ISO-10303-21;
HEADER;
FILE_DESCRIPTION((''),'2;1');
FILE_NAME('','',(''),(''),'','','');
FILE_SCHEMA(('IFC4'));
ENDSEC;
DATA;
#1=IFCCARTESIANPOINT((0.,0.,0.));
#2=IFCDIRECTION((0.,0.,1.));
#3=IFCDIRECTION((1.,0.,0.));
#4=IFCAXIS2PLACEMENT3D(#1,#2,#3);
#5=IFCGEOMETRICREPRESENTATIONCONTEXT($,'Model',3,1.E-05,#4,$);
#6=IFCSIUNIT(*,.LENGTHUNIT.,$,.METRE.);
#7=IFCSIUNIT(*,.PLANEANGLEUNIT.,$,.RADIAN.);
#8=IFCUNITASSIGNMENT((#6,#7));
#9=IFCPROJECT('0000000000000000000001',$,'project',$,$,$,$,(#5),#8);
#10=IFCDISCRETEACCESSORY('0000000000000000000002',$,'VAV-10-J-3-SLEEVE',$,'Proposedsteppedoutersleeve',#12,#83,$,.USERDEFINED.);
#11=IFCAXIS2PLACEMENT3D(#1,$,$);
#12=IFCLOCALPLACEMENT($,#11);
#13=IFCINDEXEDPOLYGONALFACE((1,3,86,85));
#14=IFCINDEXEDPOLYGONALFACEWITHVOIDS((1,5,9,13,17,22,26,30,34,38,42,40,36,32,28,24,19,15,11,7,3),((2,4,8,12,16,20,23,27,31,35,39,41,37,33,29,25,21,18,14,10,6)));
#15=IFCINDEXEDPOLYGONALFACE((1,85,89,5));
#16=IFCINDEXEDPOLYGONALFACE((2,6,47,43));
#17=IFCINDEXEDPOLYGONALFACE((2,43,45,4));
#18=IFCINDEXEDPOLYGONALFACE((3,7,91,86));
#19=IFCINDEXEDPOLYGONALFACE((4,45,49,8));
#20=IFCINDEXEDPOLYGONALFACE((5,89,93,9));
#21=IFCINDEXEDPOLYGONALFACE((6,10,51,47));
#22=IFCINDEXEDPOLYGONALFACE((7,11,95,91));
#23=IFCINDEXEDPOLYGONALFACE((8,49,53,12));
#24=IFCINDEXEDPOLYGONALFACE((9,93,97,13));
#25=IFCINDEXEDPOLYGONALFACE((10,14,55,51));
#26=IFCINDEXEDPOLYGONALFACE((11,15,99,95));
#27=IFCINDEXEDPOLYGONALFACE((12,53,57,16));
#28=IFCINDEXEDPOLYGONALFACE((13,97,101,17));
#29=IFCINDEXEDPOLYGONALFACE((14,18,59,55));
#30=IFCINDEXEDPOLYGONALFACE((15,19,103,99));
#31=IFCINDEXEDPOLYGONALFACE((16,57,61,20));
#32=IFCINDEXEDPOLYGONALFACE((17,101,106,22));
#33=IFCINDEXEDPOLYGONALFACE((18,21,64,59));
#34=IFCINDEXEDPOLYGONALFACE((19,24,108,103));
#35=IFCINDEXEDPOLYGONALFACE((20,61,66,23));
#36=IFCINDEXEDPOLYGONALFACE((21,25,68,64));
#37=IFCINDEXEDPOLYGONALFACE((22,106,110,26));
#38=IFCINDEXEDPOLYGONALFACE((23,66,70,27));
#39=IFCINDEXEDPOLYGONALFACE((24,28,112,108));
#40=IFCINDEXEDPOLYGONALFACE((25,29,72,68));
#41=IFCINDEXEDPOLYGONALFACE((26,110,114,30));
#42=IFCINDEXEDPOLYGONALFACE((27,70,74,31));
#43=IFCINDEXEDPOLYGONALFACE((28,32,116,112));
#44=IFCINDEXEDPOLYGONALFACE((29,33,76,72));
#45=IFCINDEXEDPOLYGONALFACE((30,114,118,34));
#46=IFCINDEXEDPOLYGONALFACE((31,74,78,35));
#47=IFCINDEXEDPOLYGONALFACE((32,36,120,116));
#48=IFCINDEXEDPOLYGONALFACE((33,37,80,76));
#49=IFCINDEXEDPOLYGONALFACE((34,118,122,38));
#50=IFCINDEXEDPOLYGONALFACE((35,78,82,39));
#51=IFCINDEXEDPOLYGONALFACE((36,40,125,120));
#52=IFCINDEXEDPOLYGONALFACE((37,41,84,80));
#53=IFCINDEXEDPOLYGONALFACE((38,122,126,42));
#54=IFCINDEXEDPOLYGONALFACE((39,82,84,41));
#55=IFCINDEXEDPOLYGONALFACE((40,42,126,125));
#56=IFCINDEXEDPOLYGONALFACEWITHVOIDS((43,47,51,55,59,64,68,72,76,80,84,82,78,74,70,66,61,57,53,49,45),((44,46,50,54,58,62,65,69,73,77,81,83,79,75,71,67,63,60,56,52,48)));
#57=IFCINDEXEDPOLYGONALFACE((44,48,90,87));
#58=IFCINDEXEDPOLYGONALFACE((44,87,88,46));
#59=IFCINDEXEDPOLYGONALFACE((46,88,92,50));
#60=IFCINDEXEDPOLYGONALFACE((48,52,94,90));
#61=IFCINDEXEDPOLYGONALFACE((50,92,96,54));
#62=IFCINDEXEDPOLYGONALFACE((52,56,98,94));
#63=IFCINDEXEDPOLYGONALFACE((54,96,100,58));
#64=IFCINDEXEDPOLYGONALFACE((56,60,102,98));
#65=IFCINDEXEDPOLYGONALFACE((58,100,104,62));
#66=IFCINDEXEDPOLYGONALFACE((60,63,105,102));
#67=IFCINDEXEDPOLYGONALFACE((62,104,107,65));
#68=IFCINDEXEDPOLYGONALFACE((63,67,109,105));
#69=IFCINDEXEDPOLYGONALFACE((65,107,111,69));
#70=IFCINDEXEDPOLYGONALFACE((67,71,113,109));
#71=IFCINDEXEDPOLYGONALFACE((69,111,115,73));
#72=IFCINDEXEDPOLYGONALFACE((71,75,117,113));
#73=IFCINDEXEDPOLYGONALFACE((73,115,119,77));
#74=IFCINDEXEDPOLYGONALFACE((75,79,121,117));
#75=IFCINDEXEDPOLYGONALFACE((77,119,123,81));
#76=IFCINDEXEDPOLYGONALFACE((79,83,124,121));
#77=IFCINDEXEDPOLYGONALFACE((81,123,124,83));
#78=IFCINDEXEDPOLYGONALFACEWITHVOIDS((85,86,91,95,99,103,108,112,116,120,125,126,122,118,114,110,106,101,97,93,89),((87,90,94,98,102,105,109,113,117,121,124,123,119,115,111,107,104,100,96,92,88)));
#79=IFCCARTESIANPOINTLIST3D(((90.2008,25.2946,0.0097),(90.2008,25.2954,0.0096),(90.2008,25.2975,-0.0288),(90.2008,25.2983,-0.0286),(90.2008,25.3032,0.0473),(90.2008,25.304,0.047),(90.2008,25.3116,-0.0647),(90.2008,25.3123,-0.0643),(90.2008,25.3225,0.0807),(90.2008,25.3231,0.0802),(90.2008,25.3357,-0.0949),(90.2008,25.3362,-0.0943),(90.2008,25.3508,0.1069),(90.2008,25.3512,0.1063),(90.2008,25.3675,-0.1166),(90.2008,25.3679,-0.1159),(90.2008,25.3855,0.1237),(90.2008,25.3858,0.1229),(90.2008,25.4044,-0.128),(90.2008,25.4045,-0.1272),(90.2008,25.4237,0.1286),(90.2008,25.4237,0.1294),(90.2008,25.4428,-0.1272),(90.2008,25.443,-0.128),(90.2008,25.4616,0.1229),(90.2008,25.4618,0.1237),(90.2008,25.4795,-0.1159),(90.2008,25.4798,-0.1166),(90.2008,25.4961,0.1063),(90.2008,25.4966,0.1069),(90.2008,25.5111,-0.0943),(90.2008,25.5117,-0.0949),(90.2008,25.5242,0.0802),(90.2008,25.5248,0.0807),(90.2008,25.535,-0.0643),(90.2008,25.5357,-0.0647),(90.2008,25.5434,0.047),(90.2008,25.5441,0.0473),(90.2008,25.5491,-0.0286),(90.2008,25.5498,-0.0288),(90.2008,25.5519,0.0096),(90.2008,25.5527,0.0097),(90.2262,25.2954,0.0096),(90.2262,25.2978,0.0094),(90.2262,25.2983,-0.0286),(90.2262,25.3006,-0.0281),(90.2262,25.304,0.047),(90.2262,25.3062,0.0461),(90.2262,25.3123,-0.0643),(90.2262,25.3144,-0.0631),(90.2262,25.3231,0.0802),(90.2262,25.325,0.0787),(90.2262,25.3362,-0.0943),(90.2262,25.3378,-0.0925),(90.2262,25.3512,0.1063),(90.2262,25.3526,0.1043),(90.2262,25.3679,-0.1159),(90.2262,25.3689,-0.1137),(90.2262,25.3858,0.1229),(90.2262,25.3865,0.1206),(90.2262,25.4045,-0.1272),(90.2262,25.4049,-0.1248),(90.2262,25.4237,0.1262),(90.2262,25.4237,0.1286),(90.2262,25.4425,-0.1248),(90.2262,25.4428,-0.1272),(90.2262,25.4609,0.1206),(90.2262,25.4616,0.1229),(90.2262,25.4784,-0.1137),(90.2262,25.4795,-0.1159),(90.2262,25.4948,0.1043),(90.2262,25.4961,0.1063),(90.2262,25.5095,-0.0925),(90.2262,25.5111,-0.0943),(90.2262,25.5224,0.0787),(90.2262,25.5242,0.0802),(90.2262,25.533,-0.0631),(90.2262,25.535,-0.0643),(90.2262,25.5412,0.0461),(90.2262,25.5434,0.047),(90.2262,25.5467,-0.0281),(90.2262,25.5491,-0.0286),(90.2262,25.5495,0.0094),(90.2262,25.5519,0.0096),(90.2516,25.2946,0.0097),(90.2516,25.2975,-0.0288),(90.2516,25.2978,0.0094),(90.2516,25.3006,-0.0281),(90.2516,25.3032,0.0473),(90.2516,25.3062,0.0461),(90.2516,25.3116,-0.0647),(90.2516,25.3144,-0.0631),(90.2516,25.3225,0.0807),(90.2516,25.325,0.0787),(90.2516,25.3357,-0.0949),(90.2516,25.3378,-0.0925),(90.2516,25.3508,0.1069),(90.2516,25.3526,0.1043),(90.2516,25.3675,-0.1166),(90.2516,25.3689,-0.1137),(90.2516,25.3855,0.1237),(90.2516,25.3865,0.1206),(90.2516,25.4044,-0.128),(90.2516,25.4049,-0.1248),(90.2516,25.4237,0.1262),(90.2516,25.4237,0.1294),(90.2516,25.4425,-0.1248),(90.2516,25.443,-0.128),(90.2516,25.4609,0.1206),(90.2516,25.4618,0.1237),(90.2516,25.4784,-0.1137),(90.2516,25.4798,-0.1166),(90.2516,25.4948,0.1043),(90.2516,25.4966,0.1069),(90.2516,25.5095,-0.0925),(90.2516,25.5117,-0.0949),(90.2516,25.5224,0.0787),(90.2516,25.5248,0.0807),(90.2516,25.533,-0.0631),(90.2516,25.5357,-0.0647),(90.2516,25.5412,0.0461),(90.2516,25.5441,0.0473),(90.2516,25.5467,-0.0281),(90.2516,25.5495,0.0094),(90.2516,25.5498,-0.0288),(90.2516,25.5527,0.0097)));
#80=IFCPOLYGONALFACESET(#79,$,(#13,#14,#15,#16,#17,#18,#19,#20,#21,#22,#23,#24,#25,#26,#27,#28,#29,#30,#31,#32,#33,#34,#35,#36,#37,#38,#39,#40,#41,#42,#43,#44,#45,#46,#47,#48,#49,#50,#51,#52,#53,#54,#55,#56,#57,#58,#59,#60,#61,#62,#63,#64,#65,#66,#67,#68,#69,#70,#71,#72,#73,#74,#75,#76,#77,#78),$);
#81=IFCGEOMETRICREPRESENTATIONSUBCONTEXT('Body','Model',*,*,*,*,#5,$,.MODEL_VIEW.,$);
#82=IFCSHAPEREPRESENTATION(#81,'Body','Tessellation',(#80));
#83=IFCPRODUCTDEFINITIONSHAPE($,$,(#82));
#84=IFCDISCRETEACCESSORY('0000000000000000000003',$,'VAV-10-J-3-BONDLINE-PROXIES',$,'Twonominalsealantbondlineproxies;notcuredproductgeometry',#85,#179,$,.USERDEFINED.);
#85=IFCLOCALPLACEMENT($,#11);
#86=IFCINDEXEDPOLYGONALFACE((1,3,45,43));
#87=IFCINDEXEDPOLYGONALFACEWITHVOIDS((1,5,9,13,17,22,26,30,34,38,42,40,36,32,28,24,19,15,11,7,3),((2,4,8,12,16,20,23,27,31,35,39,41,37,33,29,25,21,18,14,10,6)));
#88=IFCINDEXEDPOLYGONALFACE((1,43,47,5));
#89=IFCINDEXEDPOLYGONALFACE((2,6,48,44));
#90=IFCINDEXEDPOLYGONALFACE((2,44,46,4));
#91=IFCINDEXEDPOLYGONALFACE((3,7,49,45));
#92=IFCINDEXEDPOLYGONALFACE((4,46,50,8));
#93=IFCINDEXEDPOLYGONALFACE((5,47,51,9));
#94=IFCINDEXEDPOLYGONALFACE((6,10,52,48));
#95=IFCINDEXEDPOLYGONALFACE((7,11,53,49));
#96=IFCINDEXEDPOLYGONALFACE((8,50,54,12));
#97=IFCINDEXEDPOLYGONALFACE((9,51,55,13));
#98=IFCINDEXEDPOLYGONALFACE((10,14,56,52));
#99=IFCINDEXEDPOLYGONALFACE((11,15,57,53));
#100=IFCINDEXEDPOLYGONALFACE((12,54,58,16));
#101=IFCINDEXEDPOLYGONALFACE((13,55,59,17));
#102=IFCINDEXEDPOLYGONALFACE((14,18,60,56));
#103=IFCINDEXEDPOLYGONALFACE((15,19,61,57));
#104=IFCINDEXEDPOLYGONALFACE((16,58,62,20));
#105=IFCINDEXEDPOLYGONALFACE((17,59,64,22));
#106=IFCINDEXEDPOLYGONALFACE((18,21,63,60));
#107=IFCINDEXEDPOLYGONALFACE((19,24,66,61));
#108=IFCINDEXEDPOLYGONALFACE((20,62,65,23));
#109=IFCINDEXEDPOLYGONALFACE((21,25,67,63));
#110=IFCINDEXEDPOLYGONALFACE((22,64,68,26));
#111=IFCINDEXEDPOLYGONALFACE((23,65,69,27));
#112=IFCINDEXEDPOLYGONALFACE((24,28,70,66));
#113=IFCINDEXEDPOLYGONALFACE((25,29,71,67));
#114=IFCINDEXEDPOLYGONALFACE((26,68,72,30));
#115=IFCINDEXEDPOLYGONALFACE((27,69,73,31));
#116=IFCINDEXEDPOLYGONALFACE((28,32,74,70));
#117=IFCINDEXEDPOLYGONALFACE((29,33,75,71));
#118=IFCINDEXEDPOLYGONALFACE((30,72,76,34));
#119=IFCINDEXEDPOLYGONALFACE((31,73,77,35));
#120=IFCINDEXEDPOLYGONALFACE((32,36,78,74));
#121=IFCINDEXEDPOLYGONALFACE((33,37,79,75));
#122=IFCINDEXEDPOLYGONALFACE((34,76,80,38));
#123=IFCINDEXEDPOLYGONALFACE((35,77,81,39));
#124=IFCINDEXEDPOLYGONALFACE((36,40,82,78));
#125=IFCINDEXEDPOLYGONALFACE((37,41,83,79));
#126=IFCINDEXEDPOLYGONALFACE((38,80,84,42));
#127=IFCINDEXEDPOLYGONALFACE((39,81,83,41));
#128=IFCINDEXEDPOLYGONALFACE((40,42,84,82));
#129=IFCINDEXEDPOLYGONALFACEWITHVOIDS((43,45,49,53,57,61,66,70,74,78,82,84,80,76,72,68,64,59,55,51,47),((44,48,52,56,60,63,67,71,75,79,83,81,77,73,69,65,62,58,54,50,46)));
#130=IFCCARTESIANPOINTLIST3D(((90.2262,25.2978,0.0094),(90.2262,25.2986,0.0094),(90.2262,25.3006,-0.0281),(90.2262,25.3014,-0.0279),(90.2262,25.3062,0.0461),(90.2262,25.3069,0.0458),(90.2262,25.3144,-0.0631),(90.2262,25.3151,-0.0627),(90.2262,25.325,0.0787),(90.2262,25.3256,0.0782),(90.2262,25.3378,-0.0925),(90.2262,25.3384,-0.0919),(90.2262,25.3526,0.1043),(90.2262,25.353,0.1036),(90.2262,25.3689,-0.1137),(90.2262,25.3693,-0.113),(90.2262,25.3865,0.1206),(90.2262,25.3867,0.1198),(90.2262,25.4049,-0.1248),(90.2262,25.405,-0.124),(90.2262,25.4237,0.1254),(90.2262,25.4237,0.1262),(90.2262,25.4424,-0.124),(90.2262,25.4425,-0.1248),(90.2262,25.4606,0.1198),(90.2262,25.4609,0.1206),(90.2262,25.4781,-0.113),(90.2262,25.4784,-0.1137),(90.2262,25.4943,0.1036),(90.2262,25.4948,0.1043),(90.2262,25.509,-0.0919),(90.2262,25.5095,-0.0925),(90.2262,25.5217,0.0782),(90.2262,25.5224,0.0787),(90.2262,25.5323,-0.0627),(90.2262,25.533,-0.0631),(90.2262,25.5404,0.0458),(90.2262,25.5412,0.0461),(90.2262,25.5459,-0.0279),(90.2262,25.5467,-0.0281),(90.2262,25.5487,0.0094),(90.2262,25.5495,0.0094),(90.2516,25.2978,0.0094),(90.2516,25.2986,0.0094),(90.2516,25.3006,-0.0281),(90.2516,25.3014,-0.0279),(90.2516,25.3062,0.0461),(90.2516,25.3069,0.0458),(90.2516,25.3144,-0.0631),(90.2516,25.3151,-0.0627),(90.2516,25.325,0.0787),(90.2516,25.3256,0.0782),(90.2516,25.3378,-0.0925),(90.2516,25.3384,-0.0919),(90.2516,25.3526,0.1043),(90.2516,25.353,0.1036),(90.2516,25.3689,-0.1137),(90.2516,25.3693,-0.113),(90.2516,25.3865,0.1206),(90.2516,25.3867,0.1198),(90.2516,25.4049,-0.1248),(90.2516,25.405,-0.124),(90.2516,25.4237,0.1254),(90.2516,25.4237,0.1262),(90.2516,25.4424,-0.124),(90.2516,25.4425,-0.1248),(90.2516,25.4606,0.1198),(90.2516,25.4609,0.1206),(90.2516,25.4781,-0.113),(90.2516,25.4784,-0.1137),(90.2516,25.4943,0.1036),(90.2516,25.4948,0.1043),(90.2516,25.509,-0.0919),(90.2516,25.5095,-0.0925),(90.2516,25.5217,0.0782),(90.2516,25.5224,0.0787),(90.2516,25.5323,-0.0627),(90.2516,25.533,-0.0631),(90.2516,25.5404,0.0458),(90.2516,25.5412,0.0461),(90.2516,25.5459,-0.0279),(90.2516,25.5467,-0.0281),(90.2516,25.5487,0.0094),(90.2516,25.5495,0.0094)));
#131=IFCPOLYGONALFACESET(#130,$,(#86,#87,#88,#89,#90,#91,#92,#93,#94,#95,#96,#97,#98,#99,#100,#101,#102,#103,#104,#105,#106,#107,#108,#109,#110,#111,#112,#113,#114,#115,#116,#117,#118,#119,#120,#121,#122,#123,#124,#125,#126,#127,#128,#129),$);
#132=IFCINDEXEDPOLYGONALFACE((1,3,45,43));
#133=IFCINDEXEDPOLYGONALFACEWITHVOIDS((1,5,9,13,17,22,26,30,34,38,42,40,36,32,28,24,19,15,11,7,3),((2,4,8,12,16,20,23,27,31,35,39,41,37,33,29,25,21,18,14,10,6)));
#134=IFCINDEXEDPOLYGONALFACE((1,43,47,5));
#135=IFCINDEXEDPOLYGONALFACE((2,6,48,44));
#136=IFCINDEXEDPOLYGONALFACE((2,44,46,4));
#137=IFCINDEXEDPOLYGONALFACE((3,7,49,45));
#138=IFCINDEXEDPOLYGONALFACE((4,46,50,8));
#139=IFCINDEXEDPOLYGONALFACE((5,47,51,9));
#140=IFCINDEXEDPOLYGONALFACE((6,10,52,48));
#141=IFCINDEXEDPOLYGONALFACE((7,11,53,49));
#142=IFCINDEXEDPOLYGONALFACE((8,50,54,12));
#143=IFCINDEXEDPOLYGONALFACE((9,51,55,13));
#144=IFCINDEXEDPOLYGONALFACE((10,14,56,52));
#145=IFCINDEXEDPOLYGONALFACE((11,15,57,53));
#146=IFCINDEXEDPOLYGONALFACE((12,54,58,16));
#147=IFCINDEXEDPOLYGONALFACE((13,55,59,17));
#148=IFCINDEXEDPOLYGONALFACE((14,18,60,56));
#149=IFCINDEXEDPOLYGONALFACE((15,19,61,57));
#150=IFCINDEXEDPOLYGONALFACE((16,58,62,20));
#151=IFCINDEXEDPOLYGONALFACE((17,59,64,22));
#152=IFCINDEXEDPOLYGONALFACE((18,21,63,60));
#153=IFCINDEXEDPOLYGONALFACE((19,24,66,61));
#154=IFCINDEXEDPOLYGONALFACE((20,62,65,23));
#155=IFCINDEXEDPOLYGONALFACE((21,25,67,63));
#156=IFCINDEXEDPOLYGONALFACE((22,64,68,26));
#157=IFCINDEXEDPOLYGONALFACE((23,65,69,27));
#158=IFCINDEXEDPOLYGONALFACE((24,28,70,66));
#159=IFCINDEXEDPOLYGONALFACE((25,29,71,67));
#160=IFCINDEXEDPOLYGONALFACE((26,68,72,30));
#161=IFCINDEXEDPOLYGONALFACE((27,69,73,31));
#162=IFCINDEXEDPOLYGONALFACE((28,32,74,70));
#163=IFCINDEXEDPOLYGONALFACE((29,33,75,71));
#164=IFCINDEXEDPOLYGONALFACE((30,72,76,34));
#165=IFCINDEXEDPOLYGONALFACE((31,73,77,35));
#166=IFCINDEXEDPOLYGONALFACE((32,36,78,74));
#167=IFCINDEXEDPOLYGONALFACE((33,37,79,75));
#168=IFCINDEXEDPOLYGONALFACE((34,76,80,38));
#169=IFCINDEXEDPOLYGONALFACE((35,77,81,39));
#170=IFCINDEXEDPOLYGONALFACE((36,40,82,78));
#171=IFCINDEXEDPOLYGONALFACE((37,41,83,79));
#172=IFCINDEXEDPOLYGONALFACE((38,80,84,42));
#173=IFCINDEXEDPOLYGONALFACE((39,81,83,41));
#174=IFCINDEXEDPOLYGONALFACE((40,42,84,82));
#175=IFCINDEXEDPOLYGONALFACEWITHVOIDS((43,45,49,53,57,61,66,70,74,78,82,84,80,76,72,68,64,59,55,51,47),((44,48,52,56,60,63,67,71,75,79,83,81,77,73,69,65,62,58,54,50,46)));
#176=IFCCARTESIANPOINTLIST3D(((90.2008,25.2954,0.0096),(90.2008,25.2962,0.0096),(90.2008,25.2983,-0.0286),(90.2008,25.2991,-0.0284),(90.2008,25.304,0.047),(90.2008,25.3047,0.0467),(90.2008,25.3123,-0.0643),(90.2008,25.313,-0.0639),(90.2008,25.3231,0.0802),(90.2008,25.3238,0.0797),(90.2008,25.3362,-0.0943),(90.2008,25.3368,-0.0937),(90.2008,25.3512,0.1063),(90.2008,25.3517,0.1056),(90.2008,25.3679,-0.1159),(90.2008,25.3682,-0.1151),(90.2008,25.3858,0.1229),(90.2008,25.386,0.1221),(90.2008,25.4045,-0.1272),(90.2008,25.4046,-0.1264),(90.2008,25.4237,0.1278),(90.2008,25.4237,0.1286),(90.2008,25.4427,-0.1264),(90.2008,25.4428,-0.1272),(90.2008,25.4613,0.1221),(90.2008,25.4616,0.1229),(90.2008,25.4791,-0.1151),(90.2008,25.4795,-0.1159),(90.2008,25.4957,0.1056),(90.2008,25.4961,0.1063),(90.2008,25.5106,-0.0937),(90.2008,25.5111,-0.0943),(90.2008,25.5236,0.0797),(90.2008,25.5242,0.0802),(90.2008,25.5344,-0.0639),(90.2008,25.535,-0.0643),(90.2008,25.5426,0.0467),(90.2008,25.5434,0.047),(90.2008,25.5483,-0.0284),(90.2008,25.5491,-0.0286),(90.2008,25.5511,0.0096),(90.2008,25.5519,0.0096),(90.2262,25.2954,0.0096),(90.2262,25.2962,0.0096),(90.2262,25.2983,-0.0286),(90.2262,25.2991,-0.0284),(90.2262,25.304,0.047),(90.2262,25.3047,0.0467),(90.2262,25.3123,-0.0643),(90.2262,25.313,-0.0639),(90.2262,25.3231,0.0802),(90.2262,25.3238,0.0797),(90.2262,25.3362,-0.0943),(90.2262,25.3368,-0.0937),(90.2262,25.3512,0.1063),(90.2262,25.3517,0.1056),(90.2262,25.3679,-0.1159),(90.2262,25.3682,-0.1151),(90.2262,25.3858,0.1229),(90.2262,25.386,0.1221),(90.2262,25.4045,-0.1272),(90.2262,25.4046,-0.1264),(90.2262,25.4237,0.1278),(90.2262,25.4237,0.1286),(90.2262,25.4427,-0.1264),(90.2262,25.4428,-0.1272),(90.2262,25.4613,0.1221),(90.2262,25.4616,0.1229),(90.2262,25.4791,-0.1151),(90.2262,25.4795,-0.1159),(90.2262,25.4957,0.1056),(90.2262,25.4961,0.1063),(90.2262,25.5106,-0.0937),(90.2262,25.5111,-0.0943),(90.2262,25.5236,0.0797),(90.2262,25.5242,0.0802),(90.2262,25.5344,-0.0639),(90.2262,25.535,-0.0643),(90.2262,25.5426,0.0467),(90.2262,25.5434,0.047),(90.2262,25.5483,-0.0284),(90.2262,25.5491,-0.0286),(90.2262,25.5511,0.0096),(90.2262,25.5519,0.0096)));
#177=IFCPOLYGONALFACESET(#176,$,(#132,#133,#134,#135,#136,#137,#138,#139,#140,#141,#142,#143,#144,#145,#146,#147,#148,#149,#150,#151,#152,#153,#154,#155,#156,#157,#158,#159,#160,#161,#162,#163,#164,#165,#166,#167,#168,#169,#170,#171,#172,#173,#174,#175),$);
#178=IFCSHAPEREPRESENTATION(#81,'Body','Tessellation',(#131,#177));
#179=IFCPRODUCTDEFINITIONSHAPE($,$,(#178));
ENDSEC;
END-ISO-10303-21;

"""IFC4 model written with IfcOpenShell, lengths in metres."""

from ifc_helpers import new_model, entity, si_unit, frame, origin_with_axes, place, context, subcontext, project, element, save


model = new_model("IFC4")

# Units and contexts
model_context = context("Model", 3, precision=1e-05, world=origin_with_axes())
body_context = subcontext(model_context, "Body", "Model", "MODEL_VIEW")
ifc_project = project(units=[si_unit("LENGTHUNIT", "METRE"), si_unit("PLANEANGLEUNIT", "RADIAN")], contexts=[model_context])

# Discrete accessories
discrete_accessory_1_placement = place(None, frame((90.2262, 25.4237, 0.0), z_axis=(0.0, -1.0, 0.0), x_axis=(0.0, 0.0, 1.0)))
element("IfcDiscreteAccessory", 1, at=discrete_accessory_1_placement, Name="VAV-10-J-3-SLEEVE", ObjectType="Proposedsteppedoutersleeve", PredefinedType="USERDEFINED", context=body_context, shape_type="SweptSolid", body=[
    entity("IfcRevolvedAreaSolid", entity("IfcArbitraryClosedProfileDef", "AREA", None, entity("IfcPolyline", [entity("IfcCartesianPoint", [0.1262, -0.0254]), entity("IfcCartesianPoint", [0.1294, -0.0254]), entity("IfcCartesianPoint", [0.1294, 0.0254]), entity("IfcCartesianPoint", [0.1286, 0.0254]), entity("IfcCartesianPoint", [0.1286, 0.0]), entity("IfcCartesianPoint", [0.1262, 0.0]), entity("IfcCartesianPoint", [0.1262, -0.0254])])), entity("IfcAxis2Placement3D", entity("IfcCartesianPoint", [0.0, 0.0, 0.0])), entity("IfcAxis1Placement", entity("IfcCartesianPoint", [0.0, 0.0, 0.0]), entity("IfcDirection", [0.0, 1.0, 0.0])), 6.283185),
])
discrete_accessory_2_placement = place(None, frame((90.2262, 25.4237, 0.0), z_axis=(0.0, -1.0, 0.0), x_axis=(0.0, 0.0, 1.0)))
element("IfcDiscreteAccessory", 2, at=discrete_accessory_2_placement, Name="VAV-10-J-3-BONDLINE-PROXIES", ObjectType="Twonominalsealantbondlineproxies;notcuredproductgeometry", PredefinedType="USERDEFINED", context=body_context, shape_type="SweptSolid", body=[
    entity("IfcRevolvedAreaSolid", entity("IfcArbitraryClosedProfileDef", "AREA", None, entity("IfcPolyline", [entity("IfcCartesianPoint", [0.1254, -0.0254]), entity("IfcCartesianPoint", [0.1262, -0.0254]), entity("IfcCartesianPoint", [0.1262, 0.0]), entity("IfcCartesianPoint", [0.1254, 0.0]), entity("IfcCartesianPoint", [0.1254, -0.0254])])), entity("IfcAxis2Placement3D", entity("IfcCartesianPoint", [0.0, 0.0, 0.0])), entity("IfcAxis1Placement", entity("IfcCartesianPoint", [0.0, 0.0, 0.0]), entity("IfcDirection", [0.0, 1.0, 0.0])), 6.283185),
    entity("IfcRevolvedAreaSolid", entity("IfcArbitraryClosedProfileDef", "AREA", None, entity("IfcPolyline", [entity("IfcCartesianPoint", [0.1278, 0.0]), entity("IfcCartesianPoint", [0.1286, 0.0]), entity("IfcCartesianPoint", [0.1286, 0.0254]), entity("IfcCartesianPoint", [0.1278, 0.0254]), entity("IfcCartesianPoint", [0.1278, 0.0])])), entity("IfcAxis2Placement3D", entity("IfcCartesianPoint", [0.0, 0.0, 0.0])), entity("IfcAxis1Placement", entity("IfcCartesianPoint", [0.0, 0.0, 0.0]), entity("IfcDirection", [0.0, 1.0, 0.0])), 6.283185),
])

save(model, "model.ifc")
